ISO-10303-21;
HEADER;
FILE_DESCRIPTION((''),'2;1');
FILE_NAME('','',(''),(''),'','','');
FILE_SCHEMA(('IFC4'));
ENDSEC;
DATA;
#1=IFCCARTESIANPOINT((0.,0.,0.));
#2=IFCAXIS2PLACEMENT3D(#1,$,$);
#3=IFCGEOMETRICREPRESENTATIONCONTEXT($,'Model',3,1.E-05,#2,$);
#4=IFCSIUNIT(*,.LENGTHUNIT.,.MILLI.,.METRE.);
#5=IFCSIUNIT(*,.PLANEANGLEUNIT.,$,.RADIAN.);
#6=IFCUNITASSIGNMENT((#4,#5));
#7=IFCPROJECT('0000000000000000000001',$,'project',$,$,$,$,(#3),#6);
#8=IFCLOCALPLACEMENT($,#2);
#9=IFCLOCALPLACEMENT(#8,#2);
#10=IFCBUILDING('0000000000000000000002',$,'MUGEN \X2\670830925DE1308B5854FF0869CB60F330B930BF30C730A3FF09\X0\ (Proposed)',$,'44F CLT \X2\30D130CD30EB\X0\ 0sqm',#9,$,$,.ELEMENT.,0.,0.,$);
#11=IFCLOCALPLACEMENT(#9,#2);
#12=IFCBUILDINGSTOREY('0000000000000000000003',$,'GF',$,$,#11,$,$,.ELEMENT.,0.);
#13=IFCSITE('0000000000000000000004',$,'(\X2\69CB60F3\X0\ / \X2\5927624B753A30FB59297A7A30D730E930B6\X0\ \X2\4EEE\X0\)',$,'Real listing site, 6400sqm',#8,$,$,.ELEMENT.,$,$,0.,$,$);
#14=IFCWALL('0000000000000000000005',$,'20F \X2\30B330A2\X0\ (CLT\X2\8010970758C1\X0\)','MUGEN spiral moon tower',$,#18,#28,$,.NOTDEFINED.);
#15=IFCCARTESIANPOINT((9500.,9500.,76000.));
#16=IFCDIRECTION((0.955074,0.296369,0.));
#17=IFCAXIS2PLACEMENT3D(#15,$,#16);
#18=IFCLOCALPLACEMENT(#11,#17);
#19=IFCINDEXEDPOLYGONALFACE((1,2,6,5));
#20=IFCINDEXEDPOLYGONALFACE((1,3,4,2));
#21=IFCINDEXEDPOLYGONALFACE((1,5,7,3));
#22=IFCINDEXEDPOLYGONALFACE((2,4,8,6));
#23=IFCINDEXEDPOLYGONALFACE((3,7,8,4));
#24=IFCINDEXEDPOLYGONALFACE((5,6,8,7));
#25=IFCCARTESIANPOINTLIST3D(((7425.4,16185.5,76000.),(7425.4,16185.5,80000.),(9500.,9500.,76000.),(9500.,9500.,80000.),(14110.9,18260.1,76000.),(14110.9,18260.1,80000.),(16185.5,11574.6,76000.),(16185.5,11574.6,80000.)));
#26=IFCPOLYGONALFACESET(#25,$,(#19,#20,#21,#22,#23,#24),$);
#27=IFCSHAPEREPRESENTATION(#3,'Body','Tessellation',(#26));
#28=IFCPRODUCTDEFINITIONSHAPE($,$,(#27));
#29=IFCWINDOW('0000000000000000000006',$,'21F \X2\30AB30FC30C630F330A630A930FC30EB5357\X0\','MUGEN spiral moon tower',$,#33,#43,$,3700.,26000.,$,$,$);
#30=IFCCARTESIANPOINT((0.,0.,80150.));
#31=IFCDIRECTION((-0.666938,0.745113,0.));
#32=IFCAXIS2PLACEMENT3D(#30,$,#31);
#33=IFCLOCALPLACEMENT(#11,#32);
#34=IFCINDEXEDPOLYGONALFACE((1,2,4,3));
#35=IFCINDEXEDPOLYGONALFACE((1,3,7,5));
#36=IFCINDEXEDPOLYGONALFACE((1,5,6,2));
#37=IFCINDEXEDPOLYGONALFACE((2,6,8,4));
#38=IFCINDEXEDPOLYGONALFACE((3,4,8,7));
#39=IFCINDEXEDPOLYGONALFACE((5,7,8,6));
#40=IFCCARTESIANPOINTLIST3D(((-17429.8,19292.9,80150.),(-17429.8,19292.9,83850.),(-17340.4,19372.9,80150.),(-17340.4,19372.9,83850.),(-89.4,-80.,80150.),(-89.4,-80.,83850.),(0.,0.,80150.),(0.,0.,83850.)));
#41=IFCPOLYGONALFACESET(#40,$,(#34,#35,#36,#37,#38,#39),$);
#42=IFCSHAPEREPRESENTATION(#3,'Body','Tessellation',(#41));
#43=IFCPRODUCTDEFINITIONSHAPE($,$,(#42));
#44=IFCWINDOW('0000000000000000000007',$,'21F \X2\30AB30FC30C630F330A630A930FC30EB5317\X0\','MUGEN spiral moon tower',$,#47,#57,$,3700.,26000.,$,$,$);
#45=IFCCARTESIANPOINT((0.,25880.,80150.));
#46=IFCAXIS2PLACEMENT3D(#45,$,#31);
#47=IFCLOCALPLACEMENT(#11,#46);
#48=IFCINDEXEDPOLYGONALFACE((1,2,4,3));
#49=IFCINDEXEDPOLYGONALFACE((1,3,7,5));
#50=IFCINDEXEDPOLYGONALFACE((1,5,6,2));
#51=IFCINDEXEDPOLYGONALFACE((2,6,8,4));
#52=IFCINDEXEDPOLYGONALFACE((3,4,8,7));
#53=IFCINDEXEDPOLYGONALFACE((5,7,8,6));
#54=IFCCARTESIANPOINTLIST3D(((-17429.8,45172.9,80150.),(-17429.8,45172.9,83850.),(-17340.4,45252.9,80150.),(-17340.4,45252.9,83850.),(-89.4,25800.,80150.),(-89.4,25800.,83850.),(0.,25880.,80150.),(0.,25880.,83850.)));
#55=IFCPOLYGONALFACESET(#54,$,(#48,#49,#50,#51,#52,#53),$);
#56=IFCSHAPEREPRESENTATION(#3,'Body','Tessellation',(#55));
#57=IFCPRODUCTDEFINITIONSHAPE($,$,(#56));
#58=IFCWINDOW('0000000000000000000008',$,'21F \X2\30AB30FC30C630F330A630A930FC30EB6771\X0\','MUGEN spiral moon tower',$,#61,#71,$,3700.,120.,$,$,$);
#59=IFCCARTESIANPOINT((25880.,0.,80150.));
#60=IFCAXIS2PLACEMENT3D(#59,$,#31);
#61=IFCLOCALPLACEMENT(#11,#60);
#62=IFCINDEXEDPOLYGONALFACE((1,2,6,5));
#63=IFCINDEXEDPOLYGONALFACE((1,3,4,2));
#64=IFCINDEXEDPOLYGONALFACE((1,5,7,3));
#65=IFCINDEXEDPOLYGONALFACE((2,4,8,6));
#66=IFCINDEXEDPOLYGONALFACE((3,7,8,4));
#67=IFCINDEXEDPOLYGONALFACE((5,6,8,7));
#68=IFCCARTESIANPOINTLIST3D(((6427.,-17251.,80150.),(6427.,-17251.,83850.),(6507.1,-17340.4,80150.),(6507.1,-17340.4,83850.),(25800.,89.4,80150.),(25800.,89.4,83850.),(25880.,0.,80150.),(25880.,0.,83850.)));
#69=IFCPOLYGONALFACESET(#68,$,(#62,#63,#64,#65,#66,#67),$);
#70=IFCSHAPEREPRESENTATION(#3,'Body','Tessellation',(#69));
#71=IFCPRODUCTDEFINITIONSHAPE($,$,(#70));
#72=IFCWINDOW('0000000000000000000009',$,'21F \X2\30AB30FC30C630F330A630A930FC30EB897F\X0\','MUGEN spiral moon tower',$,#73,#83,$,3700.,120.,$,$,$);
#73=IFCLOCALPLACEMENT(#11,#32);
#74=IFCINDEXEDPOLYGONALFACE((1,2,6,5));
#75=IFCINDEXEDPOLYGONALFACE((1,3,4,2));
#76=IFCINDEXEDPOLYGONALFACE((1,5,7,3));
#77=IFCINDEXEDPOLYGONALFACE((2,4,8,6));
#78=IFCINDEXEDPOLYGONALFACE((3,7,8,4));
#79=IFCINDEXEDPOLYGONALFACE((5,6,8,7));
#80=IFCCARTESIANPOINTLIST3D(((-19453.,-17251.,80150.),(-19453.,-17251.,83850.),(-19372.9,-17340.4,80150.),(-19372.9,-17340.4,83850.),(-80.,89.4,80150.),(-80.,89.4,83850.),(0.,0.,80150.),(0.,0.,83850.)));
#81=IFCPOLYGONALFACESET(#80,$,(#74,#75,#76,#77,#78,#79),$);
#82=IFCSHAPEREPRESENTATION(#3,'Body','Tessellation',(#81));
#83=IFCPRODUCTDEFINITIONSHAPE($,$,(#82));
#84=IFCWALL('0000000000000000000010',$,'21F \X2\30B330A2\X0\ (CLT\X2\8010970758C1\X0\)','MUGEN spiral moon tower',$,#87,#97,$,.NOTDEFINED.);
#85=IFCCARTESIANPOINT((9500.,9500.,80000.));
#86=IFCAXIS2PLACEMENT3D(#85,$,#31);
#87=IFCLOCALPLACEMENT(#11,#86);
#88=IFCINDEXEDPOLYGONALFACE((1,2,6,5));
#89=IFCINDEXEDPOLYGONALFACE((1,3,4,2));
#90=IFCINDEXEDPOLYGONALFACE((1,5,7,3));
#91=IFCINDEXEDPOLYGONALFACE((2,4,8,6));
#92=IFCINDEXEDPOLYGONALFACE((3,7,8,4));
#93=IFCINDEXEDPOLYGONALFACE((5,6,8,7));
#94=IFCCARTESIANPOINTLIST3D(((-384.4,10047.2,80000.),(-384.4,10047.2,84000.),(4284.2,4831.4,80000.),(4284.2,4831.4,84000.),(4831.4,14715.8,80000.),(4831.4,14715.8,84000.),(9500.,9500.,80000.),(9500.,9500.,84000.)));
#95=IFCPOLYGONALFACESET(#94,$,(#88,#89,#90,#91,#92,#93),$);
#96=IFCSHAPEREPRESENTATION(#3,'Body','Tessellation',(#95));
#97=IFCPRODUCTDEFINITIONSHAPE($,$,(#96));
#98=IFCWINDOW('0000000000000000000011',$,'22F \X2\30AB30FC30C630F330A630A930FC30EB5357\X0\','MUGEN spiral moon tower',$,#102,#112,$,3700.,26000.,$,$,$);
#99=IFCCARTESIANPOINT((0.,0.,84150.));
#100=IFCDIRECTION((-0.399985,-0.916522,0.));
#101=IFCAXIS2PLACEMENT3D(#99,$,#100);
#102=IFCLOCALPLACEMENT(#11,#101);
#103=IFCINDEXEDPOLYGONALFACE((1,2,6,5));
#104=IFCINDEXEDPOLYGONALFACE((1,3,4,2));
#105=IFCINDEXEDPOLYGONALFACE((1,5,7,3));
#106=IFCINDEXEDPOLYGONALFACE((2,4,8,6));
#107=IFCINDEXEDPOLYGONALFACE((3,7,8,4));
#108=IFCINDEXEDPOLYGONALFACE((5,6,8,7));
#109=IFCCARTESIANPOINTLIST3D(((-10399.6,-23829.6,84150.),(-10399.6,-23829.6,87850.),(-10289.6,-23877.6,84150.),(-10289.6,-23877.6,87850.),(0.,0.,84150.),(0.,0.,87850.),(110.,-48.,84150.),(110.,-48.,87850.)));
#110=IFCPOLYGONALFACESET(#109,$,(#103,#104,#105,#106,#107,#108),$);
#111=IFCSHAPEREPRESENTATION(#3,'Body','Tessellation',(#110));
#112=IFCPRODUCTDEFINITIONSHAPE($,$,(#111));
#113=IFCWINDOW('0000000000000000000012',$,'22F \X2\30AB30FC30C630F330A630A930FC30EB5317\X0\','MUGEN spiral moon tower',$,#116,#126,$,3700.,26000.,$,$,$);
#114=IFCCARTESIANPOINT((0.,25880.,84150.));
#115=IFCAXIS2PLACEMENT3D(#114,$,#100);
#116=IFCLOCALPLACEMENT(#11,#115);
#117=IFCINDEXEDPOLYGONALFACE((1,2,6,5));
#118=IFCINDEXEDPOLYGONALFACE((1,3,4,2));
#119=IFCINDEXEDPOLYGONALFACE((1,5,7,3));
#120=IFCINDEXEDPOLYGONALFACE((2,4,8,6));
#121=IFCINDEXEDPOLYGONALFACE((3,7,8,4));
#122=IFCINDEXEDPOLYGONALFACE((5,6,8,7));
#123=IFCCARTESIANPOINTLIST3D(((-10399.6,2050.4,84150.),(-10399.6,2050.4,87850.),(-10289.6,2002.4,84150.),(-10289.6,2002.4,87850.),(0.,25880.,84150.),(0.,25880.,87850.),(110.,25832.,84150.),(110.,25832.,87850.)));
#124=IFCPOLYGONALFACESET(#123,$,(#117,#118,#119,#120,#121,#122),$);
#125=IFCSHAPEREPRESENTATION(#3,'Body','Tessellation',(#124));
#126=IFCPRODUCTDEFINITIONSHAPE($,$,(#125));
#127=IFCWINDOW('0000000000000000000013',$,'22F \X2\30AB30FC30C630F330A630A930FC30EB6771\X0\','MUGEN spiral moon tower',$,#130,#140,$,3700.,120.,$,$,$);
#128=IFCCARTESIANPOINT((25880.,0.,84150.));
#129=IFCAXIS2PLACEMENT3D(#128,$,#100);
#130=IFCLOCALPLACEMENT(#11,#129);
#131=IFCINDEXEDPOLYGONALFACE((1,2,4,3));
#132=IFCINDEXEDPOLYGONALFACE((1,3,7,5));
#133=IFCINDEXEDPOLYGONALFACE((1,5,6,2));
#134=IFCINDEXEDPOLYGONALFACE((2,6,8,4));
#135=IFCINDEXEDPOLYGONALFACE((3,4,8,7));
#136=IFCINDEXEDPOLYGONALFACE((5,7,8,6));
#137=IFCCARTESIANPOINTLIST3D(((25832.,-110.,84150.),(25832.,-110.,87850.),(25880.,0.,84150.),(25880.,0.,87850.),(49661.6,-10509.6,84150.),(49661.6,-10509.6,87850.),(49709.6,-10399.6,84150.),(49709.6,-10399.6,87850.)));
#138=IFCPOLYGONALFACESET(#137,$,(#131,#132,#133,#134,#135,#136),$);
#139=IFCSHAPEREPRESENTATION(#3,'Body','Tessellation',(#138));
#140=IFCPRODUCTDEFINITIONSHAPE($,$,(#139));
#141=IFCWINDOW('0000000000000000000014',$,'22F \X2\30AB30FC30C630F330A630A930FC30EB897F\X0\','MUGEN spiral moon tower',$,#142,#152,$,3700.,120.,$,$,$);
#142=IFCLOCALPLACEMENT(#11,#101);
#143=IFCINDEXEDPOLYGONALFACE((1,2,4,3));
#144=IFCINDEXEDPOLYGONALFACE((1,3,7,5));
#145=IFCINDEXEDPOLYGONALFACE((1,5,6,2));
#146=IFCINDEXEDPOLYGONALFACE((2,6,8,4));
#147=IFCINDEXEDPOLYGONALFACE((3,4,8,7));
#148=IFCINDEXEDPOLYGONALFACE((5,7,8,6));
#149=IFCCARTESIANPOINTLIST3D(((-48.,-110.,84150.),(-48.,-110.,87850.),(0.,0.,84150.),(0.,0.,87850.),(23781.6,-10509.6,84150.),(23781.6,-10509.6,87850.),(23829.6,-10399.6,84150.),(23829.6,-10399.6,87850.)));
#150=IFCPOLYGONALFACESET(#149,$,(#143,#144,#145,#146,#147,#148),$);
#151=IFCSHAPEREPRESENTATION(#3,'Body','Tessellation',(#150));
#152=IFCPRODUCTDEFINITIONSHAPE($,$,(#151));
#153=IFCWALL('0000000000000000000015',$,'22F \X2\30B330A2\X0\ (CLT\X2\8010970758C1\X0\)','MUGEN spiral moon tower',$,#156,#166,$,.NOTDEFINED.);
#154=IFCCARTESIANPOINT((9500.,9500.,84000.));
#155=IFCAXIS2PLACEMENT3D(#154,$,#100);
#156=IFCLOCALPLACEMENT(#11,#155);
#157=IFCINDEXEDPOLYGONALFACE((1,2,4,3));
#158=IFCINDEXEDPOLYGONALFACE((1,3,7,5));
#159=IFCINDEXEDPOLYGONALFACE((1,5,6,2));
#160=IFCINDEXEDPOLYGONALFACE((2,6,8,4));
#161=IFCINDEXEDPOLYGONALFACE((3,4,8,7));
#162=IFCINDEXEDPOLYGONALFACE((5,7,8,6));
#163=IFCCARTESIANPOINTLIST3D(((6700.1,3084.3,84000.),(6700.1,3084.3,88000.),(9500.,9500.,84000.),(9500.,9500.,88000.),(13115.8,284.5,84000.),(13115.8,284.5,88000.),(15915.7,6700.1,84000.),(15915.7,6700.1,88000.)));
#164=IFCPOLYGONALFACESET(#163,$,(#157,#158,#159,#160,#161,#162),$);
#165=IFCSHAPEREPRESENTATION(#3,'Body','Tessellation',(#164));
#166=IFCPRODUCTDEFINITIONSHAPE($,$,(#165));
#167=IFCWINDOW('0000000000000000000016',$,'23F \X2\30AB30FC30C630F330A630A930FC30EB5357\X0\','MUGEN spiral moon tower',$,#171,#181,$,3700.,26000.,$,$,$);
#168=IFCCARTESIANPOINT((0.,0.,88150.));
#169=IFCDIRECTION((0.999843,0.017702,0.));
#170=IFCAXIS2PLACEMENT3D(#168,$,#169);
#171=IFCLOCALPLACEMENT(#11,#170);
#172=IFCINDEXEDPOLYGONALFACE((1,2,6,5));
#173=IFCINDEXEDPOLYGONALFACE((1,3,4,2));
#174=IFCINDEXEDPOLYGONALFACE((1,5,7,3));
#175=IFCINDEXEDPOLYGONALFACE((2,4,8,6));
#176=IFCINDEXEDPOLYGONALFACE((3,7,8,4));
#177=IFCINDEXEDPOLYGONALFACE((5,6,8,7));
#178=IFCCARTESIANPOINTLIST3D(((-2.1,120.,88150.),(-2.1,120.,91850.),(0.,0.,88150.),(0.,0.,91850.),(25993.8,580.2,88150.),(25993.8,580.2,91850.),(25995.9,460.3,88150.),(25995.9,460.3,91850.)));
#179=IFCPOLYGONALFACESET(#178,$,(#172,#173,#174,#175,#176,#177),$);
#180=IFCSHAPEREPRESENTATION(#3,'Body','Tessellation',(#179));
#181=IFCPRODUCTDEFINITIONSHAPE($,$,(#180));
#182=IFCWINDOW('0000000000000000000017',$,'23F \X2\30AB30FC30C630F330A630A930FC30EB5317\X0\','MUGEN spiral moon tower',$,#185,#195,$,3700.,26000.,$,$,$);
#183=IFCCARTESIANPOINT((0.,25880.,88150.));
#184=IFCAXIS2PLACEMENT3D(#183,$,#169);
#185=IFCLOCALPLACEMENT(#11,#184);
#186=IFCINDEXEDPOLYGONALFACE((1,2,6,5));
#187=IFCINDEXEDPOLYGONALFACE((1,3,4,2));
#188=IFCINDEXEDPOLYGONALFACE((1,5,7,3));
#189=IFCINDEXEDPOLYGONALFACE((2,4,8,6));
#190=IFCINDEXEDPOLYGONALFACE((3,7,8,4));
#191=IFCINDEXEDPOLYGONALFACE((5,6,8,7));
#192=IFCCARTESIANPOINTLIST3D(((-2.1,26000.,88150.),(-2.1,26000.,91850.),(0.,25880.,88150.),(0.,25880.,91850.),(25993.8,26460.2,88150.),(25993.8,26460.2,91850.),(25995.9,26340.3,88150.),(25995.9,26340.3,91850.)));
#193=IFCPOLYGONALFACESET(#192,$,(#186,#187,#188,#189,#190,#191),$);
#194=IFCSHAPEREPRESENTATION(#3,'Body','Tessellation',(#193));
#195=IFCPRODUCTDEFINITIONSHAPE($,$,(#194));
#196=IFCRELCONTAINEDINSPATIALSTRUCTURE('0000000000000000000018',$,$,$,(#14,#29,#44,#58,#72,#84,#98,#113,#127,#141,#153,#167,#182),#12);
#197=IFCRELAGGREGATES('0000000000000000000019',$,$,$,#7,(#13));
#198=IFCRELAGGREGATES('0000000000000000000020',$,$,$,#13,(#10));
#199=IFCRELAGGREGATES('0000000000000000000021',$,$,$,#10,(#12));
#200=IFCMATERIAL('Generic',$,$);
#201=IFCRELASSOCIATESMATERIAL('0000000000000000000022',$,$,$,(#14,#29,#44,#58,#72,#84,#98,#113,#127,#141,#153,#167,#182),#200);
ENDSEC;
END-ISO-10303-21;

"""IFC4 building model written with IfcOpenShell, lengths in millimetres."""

from ifc_helpers import new_model, si_unit, frame, frame_2d, origin, place, context, project, spatial, rectangle, extrude, material, element, save


model = new_model("IFC4")

# Units and contexts
model_context = context("Model", 3, precision=1e-05, world=origin())
ifc_project = project(units=[si_unit("LENGTHUNIT", "METRE", prefix="MILLI"), si_unit("PLANEANGLEUNIT", "RADIAN")], contexts=[model_context])

# Site, building, storey
site_placement = place(None, origin())
site = spatial("IfcSite", under=ifc_project, at=site_placement, Name="(構想 / 大手町・天空プラザ 仮)", ObjectType="Real listing site, 6400sqm", CompositionType="ELEMENT", RefElevation=0.0)
building_placement = place(site_placement, origin())
building = spatial("IfcBuilding", under=site, at=building_placement, Name="MUGEN 月を巡る塔（構想スタディ） (Proposed)", ObjectType="44F CLT パネル 0sqm", CompositionType="ELEMENT", ElevationOfRefHeight=0.0, ElevationOfTerrain=0.0)
storey_placement = place(building_placement, origin())
storey = spatial("IfcBuildingStorey", under=building, at=storey_placement, Name="GF", CompositionType="ELEMENT", Elevation=0.0)

# Shared definitions
ifc_material = material(Name="Generic")

# Wall
wall_1_placement = place(storey_placement, frame((9500.0, 9500.0, 76000.0), x_axis=(0.955074, 0.296369, 0.0)))
element("IfcWall", 1, at=wall_1_placement, inside=storey, material=ifc_material, Name="20F コア (CLT耐震壁)", Description="MUGEN spiral moon tower", PredefinedType="NOTDEFINED", context=model_context, shape_type="SweptSolid", body=[
    extrude(rectangle(XDim=7000.0, YDim=7000.0, at=frame_2d((3500.0, 3500.0))), frame((9500.0, 9500.0, 76000.0), x_axis=(0.955074, 0.296369, 0.0)), (0.0, 0.0, 1.0), 4000.0),
])

# Windows
window_1_placement = place(storey_placement, frame((0.0, 0.0, 80150.0), x_axis=(-0.666938, 0.745113, 0.0)))
element("IfcWindow", 2, at=window_1_placement, inside=storey, material=ifc_material, Name="21F カーテンウォール南", Description="MUGEN spiral moon tower", OverallHeight=3700.0, OverallWidth=26000.0, context=model_context, shape_type="SweptSolid", body=[
    extrude(rectangle(XDim=26000.0, YDim=120.0, at=frame_2d((13000.0, 60.0))), frame((0.0, 0.0, 80150.0), x_axis=(-0.666938, 0.745113, 0.0)), (0.0, 0.0, 1.0), 3700.0),
])
window_2_placement = place(storey_placement, frame((0.0, 25880.0, 80150.0), x_axis=(-0.666938, 0.745113, 0.0)))
element("IfcWindow", 3, at=window_2_placement, inside=storey, material=ifc_material, Name="21F カーテンウォール北", Description="MUGEN spiral moon tower", OverallHeight=3700.0, OverallWidth=26000.0, context=model_context, shape_type="SweptSolid", body=[
    extrude(rectangle(XDim=26000.0, YDim=120.0, at=frame_2d((13000.0, 60.0))), frame((0.0, 25880.0, 80150.0), x_axis=(-0.666938, 0.745113, 0.0)), (0.0, 0.0, 1.0), 3700.0),
])
window_3_placement = place(storey_placement, frame((25880.0, 0.0, 80150.0), x_axis=(-0.666938, 0.745113, 0.0)))
element("IfcWindow", 4, at=window_3_placement, inside=storey, material=ifc_material, Name="21F カーテンウォール東", Description="MUGEN spiral moon tower", OverallHeight=3700.0, OverallWidth=120.0, context=model_context, shape_type="SweptSolid", body=[
    extrude(rectangle(XDim=120.0, YDim=26000.0, at=frame_2d((60.0, 13000.0))), frame((25880.0, 0.0, 80150.0), x_axis=(-0.666938, 0.745113, 0.0)), (0.0, 0.0, 1.0), 3700.0),
])
window_4_placement = place(storey_placement, frame((0.0, 0.0, 80150.0), x_axis=(-0.666938, 0.745113, 0.0)))
element("IfcWindow", 5, at=window_4_placement, inside=storey, material=ifc_material, Name="21F カーテンウォール西", Description="MUGEN spiral moon tower", OverallHeight=3700.0, OverallWidth=120.0, context=model_context, shape_type="SweptSolid", body=[
    extrude(rectangle(XDim=120.0, YDim=26000.0, at=frame_2d((60.0, 13000.0))), frame((0.0, 0.0, 80150.0), x_axis=(-0.666938, 0.745113, 0.0)), (0.0, 0.0, 1.0), 3700.0),
])

# Wall
wall_2_placement = place(storey_placement, frame((9500.0, 9500.0, 80000.0), x_axis=(-0.666938, 0.745113, 0.0)))
element("IfcWall", 6, at=wall_2_placement, inside=storey, material=ifc_material, Name="21F コア (CLT耐震壁)", Description="MUGEN spiral moon tower", PredefinedType="NOTDEFINED", context=model_context, shape_type="SweptSolid", body=[
    extrude(rectangle(XDim=7000.0, YDim=7000.0, at=frame_2d((3500.0, 3500.0))), frame((9500.0, 9500.0, 80000.0), x_axis=(-0.666938, 0.745113, 0.0)), (0.0, 0.0, 1.0), 4000.0),
])

# Windows
window_5_placement = place(storey_placement, frame((0.0, 0.0, 84150.0), x_axis=(-0.399985, -0.916522, 0.0)))
element("IfcWindow", 7, at=window_5_placement, inside=storey, material=ifc_material, Name="22F カーテンウォール南", Description="MUGEN spiral moon tower", OverallHeight=3700.0, OverallWidth=26000.0, context=model_context, shape_type="SweptSolid", body=[
    extrude(rectangle(XDim=26000.0, YDim=120.0, at=frame_2d((13000.0, 60.0))), frame((0.0, 0.0, 84150.0), x_axis=(-0.399985, -0.916522, 0.0)), (0.0, 0.0, 1.0), 3700.0),
])
window_6_placement = place(storey_placement, frame((0.0, 25880.0, 84150.0), x_axis=(-0.399985, -0.916522, 0.0)))
element("IfcWindow", 8, at=window_6_placement, inside=storey, material=ifc_material, Name="22F カーテンウォール北", Description="MUGEN spiral moon tower", OverallHeight=3700.0, OverallWidth=26000.0, context=model_context, shape_type="SweptSolid", body=[
    extrude(rectangle(XDim=26000.0, YDim=120.0, at=frame_2d((13000.0, 60.0))), frame((0.0, 25880.0, 84150.0), x_axis=(-0.399985, -0.916522, 0.0)), (0.0, 0.0, 1.0), 3700.0),
])
window_7_placement = place(storey_placement, frame((25880.0, 0.0, 84150.0), x_axis=(-0.399985, -0.916522, 0.0)))
element("IfcWindow", 9, at=window_7_placement, inside=storey, material=ifc_material, Name="22F カーテンウォール東", Description="MUGEN spiral moon tower", OverallHeight=3700.0, OverallWidth=120.0, context=model_context, shape_type="SweptSolid", body=[
    extrude(rectangle(XDim=120.0, YDim=26000.0, at=frame_2d((60.0, 13000.0))), frame((25880.0, 0.0, 84150.0), x_axis=(-0.399985, -0.916522, 0.0)), (0.0, 0.0, 1.0), 3700.0),
])
window_8_placement = place(storey_placement, frame((0.0, 0.0, 84150.0), x_axis=(-0.399985, -0.916522, 0.0)))
element("IfcWindow", 10, at=window_8_placement, inside=storey, material=ifc_material, Name="22F カーテンウォール西", Description="MUGEN spiral moon tower", OverallHeight=3700.0, OverallWidth=120.0, context=model_context, shape_type="SweptSolid", body=[
    extrude(rectangle(XDim=120.0, YDim=26000.0, at=frame_2d((60.0, 13000.0))), frame((0.0, 0.0, 84150.0), x_axis=(-0.399985, -0.916522, 0.0)), (0.0, 0.0, 1.0), 3700.0),
])

# Wall
wall_3_placement = place(storey_placement, frame((9500.0, 9500.0, 84000.0), x_axis=(-0.399985, -0.916522, 0.0)))
element("IfcWall", 11, at=wall_3_placement, inside=storey, material=ifc_material, Name="22F コア (CLT耐震壁)", Description="MUGEN spiral moon tower", PredefinedType="NOTDEFINED", context=model_context, shape_type="SweptSolid", body=[
    extrude(rectangle(XDim=7000.0, YDim=7000.0, at=frame_2d((3500.0, 3500.0))), frame((9500.0, 9500.0, 84000.0), x_axis=(-0.399985, -0.916522, 0.0)), (0.0, 0.0, 1.0), 4000.0),
])

# Windows
window_9_placement = place(storey_placement, frame((0.0, 0.0, 88150.0), x_axis=(0.999843, 0.017702, 0.0)))
element("IfcWindow", 12, at=window_9_placement, inside=storey, material=ifc_material, Name="23F カーテンウォール南", Description="MUGEN spiral moon tower", OverallHeight=3700.0, OverallWidth=26000.0, context=model_context, shape_type="SweptSolid", body=[
    extrude(rectangle(XDim=26000.0, YDim=120.0, at=frame_2d((13000.0, 60.0))), frame((0.0, 0.0, 88150.0), x_axis=(0.999843, 0.017702, 0.0)), (0.0, 0.0, 1.0), 3700.0),
])
window_10_placement = place(storey_placement, frame((0.0, 25880.0, 88150.0), x_axis=(0.999843, 0.017702, 0.0)))
element("IfcWindow", 13, at=window_10_placement, inside=storey, material=ifc_material, Name="23F カーテンウォール北", Description="MUGEN spiral moon tower", OverallHeight=3700.0, OverallWidth=26000.0, context=model_context, shape_type="SweptSolid", body=[
    extrude(rectangle(XDim=26000.0, YDim=120.0, at=frame_2d((13000.0, 60.0))), frame((0.0, 25880.0, 88150.0), x_axis=(0.999843, 0.017702, 0.0)), (0.0, 0.0, 1.0), 3700.0),
])

save(model, "model.ifc")
